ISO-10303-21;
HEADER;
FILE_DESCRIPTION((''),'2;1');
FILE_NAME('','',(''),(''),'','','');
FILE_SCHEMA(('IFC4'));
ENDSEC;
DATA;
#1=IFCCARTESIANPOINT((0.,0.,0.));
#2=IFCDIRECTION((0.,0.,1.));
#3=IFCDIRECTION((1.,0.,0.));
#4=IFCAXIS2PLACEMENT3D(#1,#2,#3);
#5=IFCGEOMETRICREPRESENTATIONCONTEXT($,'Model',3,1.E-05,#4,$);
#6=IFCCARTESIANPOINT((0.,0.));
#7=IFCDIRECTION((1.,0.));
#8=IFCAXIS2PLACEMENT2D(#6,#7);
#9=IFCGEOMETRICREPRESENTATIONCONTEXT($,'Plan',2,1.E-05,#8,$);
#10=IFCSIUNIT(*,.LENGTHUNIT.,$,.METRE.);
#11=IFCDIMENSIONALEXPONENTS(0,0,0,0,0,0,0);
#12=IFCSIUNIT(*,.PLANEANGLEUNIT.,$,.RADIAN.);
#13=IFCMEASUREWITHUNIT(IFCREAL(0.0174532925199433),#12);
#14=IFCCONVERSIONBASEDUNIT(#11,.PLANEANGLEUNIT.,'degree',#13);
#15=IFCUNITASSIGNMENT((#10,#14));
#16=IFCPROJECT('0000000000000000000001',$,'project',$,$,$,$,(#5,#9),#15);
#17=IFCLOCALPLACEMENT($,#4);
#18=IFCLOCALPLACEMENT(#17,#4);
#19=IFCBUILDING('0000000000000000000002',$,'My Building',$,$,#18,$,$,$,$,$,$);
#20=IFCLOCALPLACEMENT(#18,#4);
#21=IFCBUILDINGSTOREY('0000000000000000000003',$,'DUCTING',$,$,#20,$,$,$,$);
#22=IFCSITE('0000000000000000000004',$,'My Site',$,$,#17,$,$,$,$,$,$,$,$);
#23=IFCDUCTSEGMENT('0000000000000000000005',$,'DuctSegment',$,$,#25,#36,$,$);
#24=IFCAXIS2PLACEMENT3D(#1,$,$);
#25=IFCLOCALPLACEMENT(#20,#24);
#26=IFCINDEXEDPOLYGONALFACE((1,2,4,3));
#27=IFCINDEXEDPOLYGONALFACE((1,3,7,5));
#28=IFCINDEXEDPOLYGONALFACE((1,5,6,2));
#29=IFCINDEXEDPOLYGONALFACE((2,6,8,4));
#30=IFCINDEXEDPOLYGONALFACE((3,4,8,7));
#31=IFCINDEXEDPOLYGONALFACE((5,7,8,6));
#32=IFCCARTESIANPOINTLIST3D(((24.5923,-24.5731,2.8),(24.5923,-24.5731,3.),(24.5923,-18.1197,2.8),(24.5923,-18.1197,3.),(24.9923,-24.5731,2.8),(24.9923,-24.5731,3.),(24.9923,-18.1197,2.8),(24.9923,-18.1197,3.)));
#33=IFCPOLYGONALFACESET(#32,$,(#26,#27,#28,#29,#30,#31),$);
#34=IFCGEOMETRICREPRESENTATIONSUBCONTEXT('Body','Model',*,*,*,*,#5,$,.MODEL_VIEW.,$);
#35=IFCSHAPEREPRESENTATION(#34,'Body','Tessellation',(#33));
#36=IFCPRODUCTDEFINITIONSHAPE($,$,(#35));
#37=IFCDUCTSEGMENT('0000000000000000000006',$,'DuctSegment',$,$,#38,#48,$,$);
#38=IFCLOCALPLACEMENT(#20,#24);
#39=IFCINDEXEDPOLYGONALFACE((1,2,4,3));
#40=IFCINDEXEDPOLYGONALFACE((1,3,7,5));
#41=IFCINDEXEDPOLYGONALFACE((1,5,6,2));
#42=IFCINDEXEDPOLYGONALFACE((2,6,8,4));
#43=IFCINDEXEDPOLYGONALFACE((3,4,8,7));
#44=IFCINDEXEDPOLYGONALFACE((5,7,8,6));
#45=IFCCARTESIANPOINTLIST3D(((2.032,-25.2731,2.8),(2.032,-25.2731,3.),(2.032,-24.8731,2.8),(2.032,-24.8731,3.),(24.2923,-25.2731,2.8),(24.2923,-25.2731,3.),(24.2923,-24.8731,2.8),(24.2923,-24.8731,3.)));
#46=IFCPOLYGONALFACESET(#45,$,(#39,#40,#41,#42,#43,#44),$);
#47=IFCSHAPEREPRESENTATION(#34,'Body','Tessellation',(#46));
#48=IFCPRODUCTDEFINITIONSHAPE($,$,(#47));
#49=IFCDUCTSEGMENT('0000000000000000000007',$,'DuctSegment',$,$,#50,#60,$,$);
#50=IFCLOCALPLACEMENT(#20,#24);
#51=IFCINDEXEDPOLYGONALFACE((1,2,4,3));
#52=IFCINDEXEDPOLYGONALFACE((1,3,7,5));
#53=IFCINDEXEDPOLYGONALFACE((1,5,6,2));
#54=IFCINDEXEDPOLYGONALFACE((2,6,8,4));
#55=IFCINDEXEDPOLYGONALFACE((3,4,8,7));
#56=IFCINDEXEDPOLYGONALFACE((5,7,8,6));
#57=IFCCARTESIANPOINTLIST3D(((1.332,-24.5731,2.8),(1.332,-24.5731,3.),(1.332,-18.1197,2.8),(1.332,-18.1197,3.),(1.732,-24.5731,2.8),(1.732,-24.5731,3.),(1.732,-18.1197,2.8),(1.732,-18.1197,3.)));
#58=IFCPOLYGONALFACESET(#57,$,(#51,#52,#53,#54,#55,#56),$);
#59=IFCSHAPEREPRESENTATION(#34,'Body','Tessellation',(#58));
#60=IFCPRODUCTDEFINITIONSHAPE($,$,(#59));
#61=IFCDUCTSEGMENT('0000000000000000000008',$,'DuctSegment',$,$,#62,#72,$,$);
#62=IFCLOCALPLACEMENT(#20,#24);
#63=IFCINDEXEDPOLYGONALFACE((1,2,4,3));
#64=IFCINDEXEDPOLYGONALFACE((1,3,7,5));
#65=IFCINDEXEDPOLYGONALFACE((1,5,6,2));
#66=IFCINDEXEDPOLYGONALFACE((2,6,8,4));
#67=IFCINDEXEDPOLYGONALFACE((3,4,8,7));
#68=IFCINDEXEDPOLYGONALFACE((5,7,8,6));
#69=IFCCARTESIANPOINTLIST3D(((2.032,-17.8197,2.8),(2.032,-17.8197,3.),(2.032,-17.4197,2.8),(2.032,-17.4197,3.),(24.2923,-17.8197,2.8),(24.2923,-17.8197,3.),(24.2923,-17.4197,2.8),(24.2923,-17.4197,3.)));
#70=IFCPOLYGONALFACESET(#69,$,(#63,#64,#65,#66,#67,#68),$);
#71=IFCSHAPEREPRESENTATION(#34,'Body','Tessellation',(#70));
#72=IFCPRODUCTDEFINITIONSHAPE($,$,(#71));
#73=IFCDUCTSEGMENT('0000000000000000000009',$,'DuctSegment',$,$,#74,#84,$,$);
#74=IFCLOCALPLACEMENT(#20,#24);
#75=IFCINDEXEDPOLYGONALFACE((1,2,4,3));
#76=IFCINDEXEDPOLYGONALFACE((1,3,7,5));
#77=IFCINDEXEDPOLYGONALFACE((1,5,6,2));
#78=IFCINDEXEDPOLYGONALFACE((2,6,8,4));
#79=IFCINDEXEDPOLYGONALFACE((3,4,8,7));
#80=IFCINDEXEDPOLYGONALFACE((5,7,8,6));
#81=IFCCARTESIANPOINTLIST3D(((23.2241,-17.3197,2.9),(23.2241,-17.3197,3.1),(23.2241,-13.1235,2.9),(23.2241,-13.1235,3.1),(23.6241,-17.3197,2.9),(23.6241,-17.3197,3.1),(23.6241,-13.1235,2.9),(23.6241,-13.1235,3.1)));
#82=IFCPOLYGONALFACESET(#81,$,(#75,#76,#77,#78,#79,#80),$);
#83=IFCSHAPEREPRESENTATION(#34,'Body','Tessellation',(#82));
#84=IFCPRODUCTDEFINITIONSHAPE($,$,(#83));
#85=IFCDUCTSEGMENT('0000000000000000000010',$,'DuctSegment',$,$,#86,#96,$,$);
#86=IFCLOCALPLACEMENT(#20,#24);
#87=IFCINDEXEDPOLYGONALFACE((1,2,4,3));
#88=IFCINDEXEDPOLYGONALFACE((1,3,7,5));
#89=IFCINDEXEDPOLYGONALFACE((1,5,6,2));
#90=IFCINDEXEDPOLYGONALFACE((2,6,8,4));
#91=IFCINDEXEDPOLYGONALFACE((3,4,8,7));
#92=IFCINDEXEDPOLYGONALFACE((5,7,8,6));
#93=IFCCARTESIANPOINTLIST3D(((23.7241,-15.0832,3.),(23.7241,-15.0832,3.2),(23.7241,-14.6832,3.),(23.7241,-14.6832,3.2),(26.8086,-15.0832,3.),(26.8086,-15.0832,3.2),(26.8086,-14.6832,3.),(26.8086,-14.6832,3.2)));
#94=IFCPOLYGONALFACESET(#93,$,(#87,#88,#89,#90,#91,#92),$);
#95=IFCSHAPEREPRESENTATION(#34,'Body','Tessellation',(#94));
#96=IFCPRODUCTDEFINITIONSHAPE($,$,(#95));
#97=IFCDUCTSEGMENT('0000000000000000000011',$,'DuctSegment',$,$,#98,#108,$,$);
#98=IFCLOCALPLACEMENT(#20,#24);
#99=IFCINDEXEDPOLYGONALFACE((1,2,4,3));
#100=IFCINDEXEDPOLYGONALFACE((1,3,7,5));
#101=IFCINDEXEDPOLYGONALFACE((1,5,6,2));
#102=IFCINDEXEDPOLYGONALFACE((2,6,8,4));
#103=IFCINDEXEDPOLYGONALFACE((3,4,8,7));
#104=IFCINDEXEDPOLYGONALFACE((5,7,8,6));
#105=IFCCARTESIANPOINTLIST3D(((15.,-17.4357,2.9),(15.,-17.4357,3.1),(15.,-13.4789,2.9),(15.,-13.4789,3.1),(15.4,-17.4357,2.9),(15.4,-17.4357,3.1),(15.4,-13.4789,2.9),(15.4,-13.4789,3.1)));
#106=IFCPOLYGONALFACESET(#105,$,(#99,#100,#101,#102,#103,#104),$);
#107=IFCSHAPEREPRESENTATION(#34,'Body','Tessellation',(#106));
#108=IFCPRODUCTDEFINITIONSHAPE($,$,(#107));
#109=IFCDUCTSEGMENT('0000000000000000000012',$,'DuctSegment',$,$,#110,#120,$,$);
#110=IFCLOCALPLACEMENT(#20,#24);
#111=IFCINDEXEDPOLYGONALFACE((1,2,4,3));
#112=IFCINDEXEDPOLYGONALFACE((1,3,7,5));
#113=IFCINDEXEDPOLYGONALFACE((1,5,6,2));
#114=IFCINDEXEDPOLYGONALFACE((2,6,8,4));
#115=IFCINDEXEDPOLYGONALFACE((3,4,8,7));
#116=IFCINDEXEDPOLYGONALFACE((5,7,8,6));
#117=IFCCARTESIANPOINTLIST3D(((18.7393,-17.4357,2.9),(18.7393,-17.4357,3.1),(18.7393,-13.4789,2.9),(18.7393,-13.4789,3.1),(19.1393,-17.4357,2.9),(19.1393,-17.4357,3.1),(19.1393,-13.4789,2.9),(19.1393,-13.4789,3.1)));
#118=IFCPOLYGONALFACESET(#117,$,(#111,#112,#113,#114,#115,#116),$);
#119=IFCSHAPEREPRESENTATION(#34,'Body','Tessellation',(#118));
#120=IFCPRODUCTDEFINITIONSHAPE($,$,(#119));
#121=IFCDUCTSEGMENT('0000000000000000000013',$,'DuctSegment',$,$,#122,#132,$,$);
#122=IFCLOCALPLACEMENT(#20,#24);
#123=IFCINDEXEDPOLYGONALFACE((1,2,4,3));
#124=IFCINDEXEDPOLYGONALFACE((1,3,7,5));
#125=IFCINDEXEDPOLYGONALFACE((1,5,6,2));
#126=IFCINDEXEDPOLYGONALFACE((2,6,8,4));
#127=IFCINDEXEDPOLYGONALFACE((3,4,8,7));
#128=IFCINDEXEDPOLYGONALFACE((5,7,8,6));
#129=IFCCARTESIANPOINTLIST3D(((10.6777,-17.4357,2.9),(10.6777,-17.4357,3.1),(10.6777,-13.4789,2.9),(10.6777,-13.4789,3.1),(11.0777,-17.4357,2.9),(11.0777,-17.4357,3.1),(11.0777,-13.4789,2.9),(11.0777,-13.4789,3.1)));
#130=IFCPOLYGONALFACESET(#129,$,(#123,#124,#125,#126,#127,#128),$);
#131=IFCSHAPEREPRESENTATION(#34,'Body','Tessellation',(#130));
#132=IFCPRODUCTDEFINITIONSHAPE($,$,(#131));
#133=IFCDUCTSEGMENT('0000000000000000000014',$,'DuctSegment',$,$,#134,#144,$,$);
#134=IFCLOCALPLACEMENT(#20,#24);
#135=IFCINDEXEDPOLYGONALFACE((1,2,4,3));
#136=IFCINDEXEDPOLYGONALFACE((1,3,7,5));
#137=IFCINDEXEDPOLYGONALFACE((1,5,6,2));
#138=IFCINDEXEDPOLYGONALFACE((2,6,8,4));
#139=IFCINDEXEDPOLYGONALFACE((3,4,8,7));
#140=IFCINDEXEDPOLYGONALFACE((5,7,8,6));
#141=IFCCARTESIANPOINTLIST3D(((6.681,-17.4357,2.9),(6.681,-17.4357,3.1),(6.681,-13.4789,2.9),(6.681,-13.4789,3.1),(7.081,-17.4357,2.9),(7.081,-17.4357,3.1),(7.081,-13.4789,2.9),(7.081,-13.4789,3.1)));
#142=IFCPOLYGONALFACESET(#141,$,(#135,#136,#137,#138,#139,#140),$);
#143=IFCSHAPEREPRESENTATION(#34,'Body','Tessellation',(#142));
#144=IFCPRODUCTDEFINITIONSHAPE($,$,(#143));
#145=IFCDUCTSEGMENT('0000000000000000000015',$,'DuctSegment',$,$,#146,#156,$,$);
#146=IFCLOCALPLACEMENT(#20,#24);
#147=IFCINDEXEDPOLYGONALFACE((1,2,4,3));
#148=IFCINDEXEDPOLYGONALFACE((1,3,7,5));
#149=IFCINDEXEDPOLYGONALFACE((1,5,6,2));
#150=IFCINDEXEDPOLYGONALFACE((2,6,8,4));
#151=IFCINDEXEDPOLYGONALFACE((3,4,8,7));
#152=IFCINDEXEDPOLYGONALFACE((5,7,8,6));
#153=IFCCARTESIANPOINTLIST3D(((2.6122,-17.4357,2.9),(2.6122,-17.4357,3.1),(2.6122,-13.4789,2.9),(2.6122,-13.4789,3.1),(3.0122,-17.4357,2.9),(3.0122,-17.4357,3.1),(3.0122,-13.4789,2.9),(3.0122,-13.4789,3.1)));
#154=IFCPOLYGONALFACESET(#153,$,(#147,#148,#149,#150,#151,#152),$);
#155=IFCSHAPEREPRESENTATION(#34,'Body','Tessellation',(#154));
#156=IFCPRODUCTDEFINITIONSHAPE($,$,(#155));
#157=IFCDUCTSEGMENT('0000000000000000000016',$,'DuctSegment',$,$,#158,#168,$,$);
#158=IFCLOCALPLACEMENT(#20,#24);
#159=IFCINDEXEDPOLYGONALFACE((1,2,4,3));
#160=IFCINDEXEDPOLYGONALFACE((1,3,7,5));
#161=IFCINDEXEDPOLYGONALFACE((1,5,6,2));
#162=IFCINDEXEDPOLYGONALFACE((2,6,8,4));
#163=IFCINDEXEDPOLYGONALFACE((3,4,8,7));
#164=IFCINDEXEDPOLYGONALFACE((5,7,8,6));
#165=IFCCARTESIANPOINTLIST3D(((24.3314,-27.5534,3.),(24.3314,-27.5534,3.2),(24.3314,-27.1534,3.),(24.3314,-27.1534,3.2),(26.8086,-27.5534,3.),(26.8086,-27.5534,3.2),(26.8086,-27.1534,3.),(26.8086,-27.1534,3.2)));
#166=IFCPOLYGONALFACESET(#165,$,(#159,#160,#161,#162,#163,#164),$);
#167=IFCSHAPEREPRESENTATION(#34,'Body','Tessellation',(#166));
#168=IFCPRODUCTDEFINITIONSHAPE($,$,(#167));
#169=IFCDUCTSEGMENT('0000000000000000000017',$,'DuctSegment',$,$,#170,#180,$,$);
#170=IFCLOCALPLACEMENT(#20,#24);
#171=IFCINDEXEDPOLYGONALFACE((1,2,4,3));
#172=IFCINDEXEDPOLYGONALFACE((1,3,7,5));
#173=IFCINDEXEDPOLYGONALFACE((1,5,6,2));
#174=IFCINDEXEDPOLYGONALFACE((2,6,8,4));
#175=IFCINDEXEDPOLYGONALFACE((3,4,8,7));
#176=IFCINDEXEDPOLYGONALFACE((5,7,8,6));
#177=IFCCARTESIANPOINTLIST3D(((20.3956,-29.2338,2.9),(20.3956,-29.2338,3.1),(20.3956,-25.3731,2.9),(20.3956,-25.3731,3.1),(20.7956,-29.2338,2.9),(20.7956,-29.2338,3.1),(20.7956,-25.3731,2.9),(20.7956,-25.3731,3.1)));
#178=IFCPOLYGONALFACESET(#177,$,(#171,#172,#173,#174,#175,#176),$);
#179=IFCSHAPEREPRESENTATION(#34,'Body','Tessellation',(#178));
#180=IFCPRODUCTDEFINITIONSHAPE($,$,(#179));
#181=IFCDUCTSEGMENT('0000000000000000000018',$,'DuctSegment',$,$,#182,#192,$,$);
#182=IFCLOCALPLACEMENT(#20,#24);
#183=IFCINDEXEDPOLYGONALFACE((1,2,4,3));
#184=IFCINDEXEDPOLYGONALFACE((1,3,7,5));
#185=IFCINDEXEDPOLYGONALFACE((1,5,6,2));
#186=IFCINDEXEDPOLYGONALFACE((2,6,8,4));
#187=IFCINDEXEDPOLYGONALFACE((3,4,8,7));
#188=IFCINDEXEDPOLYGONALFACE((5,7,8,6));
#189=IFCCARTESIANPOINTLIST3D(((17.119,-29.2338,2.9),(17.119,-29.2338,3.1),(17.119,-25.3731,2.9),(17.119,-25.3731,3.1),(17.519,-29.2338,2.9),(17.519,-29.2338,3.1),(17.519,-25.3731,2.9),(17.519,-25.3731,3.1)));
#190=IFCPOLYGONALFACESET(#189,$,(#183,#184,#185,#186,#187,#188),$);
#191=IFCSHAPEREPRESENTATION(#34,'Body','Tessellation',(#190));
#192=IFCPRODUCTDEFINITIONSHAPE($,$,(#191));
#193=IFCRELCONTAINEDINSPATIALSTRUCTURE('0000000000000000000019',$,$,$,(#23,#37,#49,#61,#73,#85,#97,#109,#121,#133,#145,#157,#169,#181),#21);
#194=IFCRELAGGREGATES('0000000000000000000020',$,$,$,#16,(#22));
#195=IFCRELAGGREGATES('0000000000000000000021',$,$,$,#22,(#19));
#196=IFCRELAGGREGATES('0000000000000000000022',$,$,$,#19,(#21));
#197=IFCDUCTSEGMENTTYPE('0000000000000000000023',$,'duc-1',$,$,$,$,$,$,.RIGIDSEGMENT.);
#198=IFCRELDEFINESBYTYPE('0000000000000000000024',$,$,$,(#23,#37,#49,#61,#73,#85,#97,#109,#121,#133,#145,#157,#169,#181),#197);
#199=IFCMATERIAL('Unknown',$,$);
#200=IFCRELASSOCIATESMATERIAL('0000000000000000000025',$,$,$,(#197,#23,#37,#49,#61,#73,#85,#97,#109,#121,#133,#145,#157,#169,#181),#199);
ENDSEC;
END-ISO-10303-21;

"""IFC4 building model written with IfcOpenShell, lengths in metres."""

from ifc_helpers import new_model, entity, si_unit, converted_unit, frame, origin_with_axes, origin_2d_with_axis, place, context, subcontext, project, spatial, rectangle, extrude, material, material_profile, profile_set, profile_usage, type_object, element, save


model = new_model("IFC4")

# Units and contexts
model_context = context("Model", 3, precision=1e-05, world=origin_with_axes())
plan_context = context("Plan", 2, precision=1e-05, world=origin_2d_with_axis())
body_context = subcontext(model_context, "Body", "Model", "MODEL_VIEW")
ifc_project = project(units=[si_unit("LENGTHUNIT", "METRE"), converted_unit("PLANEANGLEUNIT", "degree", entity("IfcReal", 0.0174532925199433), si_unit("PLANEANGLEUNIT", "RADIAN"), dimensions=[0, 0, 0, 0, 0, 0, 0])], contexts=[model_context, plan_context])

# Site, building, storey
site_placement = place(None, origin_with_axes())
site = spatial("IfcSite", under=ifc_project, at=site_placement, Name="My Site")
building_placement = place(site_placement, origin_with_axes())
building = spatial("IfcBuilding", under=site, at=building_placement, Name="My Building")
storey_placement = place(building_placement, origin_with_axes())
storey = spatial("IfcBuildingStorey", under=building, at=storey_placement, Name="DUCTING")

# Duct segments
ifc_material = material(Name="Unknown")
ifc_material_profile_1 = material_profile(ifc_material, rectangle(XDim=0.4, YDim=0.2))
ifc_profile_set_1 = profile_set([ifc_material_profile_1])
ifc_profile_usage_1 = profile_usage(ifc_profile_set_1, cardinal=5)
duct_segment_type = type_object("IfcDuctSegmentType", Name="duc-1", PredefinedType="RIGIDSEGMENT", material=ifc_profile_set_1)
duct_segment_1_placement = place(storey_placement, frame((24.7923, -18.1197, 2.9), z_axis=(0.0, -1.0, 0.0), x_axis=(1.0, 0.0, 0.0)))
element("IfcDuctSegment", 1, at=duct_segment_1_placement, inside=storey, type_object=duct_segment_type, material=ifc_profile_usage_1, Name="DuctSegment", context=body_context, shape_type="SweptSolid", body=[
    extrude(rectangle(XDim=0.4, YDim=0.2), origin_with_axes(), (0.0, 0.0, 1.0), 6.4534),
])
ifc_profile_usage_2 = profile_usage(ifc_profile_set_1, cardinal=5)
duct_segment_2_placement = place(storey_placement, frame((24.2923, -25.0731, 2.9), z_axis=(-1.0, 0.0, 0.0), x_axis=(0.0, -1.0, 0.0)))
element("IfcDuctSegment", 2, at=duct_segment_2_placement, inside=storey, type_object=duct_segment_type, material=ifc_profile_usage_2, Name="DuctSegment", context=body_context, shape_type="SweptSolid", body=[
    extrude(rectangle(XDim=0.4, YDim=0.2), origin_with_axes(), (0.0, 0.0, 1.0), 22.2603),
])
ifc_profile_usage_3 = profile_usage(ifc_profile_set_1, cardinal=5)
duct_segment_3_placement = place(storey_placement, frame((1.532, -24.5731, 2.9), z_axis=(0.0, 1.0, 0.0), x_axis=(-1.0, 0.0, 0.0)))
element("IfcDuctSegment", 3, at=duct_segment_3_placement, inside=storey, type_object=duct_segment_type, material=ifc_profile_usage_3, Name="DuctSegment", context=body_context, shape_type="SweptSolid", body=[
    extrude(rectangle(XDim=0.4, YDim=0.2), origin_with_axes(), (0.0, 0.0, 1.0), 6.4534),
])
ifc_profile_usage_4 = profile_usage(ifc_profile_set_1, cardinal=5)
duct_segment_4_placement = place(storey_placement, frame((2.032, -17.6197, 2.9), z_axis=(1.0, 0.0, 0.0), x_axis=(0.0, 1.0, 0.0)))
element("IfcDuctSegment", 4, at=duct_segment_4_placement, inside=storey, type_object=duct_segment_type, material=ifc_profile_usage_4, Name="DuctSegment", context=body_context, shape_type="SweptSolid", body=[
    extrude(rectangle(XDim=0.4, YDim=0.2), origin_with_axes(), (0.0, 0.0, 1.0), 22.2603),
])
ifc_profile_usage_5 = profile_usage(ifc_profile_set_1, cardinal=5)
duct_segment_5_placement = place(storey_placement, frame((23.4241, -17.3197, 3.0), z_axis=(0.0, 1.0, 0.0), x_axis=(-1.0, 0.0, 0.0)))
element("IfcDuctSegment", 5, at=duct_segment_5_placement, inside=storey, type_object=duct_segment_type, material=ifc_profile_usage_5, Name="DuctSegment", context=body_context, shape_type="SweptSolid", body=[
    extrude(rectangle(XDim=0.4, YDim=0.2), origin_with_axes(), (0.0, 0.0, 1.0), 4.1962),
])
ifc_profile_usage_6 = profile_usage(ifc_profile_set_1, cardinal=5)
duct_segment_6_placement = place(storey_placement, frame((23.7241, -14.8832, 3.1), z_axis=(1.0, 0.0, 0.0), x_axis=(0.0, 1.0, 0.0)))
element("IfcDuctSegment", 6, at=duct_segment_6_placement, inside=storey, type_object=duct_segment_type, material=ifc_profile_usage_6, Name="DuctSegment", context=body_context, shape_type="SweptSolid", body=[
    extrude(rectangle(XDim=0.4, YDim=0.2), origin_with_axes(), (0.0, 0.0, 1.0), 3.0846),
])
ifc_profile_usage_7 = profile_usage(ifc_profile_set_1, cardinal=5)
duct_segment_7_placement = place(storey_placement, frame((15.2, -17.4357, 3.0), z_axis=(0.0, 1.0, 0.0), x_axis=(-1.0, 0.0, 0.0)))
element("IfcDuctSegment", 7, at=duct_segment_7_placement, inside=storey, type_object=duct_segment_type, material=ifc_profile_usage_7, Name="DuctSegment", context=body_context, shape_type="SweptSolid", body=[
    extrude(rectangle(XDim=0.4, YDim=0.2), origin_with_axes(), (0.0, 0.0, 1.0), 3.9568),
])
ifc_profile_usage_8 = profile_usage(ifc_profile_set_1, cardinal=5)
duct_segment_8_placement = place(storey_placement, frame((18.9393, -17.4357, 3.0), z_axis=(0.0, 1.0, 0.0), x_axis=(-1.0, 0.0, 0.0)))
element("IfcDuctSegment", 8, at=duct_segment_8_placement, inside=storey, type_object=duct_segment_type, material=ifc_profile_usage_8, Name="DuctSegment", context=body_context, shape_type="SweptSolid", body=[
    extrude(rectangle(XDim=0.4, YDim=0.2), origin_with_axes(), (0.0, 0.0, 1.0), 3.9568),
])
ifc_profile_usage_9 = profile_usage(ifc_profile_set_1, cardinal=5)
duct_segment_9_placement = place(storey_placement, frame((10.8777, -17.4357, 3.0), z_axis=(0.0, 1.0, 0.0), x_axis=(-1.0, 0.0, 0.0)))
element("IfcDuctSegment", 9, at=duct_segment_9_placement, inside=storey, type_object=duct_segment_type, material=ifc_profile_usage_9, Name="DuctSegment", context=body_context, shape_type="SweptSolid", body=[
    extrude(rectangle(XDim=0.4, YDim=0.2), origin_with_axes(), (0.0, 0.0, 1.0), 3.9568),
])
ifc_profile_usage_10 = profile_usage(ifc_profile_set_1, cardinal=5)
duct_segment_10_placement = place(storey_placement, frame((6.881, -17.4357, 3.0), z_axis=(0.0, 1.0, 0.0), x_axis=(-1.0, 0.0, 0.0)))
element("IfcDuctSegment", 10, at=duct_segment_10_placement, inside=storey, type_object=duct_segment_type, material=ifc_profile_usage_10, Name="DuctSegment", context=body_context, shape_type="SweptSolid", body=[
    extrude(rectangle(XDim=0.4, YDim=0.2), origin_with_axes(), (0.0, 0.0, 1.0), 3.9568),
])
ifc_profile_usage_11 = profile_usage(ifc_profile_set_1, cardinal=5)
duct_segment_11_placement = place(storey_placement, frame((2.8122, -17.4357, 3.0), z_axis=(0.0, 1.0, 0.0), x_axis=(-1.0, 0.0, 0.0)))
element("IfcDuctSegment", 11, at=duct_segment_11_placement, inside=storey, type_object=duct_segment_type, material=ifc_profile_usage_11, Name="DuctSegment", context=body_context, shape_type="SweptSolid", body=[
    extrude(rectangle(XDim=0.4, YDim=0.2), origin_with_axes(), (0.0, 0.0, 1.0), 3.9568),
])
ifc_profile_usage_12 = profile_usage(ifc_profile_set_1, cardinal=5)
duct_segment_12_placement = place(storey_placement, frame((24.3314, -27.3534, 3.1), z_axis=(1.0, 0.0, 0.0), x_axis=(0.0, 1.0, 0.0)))
element("IfcDuctSegment", 12, at=duct_segment_12_placement, inside=storey, type_object=duct_segment_type, material=ifc_profile_usage_12, Name="DuctSegment", context=body_context, shape_type="SweptSolid", body=[
    extrude(rectangle(XDim=0.4, YDim=0.2), origin_with_axes(), (0.0, 0.0, 1.0), 2.4772),
])
ifc_profile_usage_13 = profile_usage(ifc_profile_set_1, cardinal=5)
duct_segment_13_placement = place(storey_placement, frame((20.5956, -29.2338, 3.0), z_axis=(0.0, 1.0, 0.0), x_axis=(-1.0, 0.0, 0.0)))
element("IfcDuctSegment", 13, at=duct_segment_13_placement, inside=storey, type_object=duct_segment_type, material=ifc_profile_usage_13, Name="DuctSegment", context=body_context, shape_type="SweptSolid", body=[
    extrude(rectangle(XDim=0.4, YDim=0.2), origin_with_axes(), (0.0, 0.0, 1.0), 3.8608),
])
ifc_profile_usage_14 = profile_usage(ifc_profile_set_1, cardinal=5)
duct_segment_14_placement = place(storey_placement, frame((17.319, -29.2338, 3.0), z_axis=(0.0, 1.0, 0.0), x_axis=(-1.0, 0.0, 0.0)))
element("IfcDuctSegment", 14, at=duct_segment_14_placement, inside=storey, type_object=duct_segment_type, material=ifc_profile_usage_14, Name="DuctSegment", context=body_context, shape_type="SweptSolid", body=[
    extrude(rectangle(XDim=0.4, YDim=0.2), origin_with_axes(), (0.0, 0.0, 1.0), 3.8608),
])

save(model, "model.ifc")
